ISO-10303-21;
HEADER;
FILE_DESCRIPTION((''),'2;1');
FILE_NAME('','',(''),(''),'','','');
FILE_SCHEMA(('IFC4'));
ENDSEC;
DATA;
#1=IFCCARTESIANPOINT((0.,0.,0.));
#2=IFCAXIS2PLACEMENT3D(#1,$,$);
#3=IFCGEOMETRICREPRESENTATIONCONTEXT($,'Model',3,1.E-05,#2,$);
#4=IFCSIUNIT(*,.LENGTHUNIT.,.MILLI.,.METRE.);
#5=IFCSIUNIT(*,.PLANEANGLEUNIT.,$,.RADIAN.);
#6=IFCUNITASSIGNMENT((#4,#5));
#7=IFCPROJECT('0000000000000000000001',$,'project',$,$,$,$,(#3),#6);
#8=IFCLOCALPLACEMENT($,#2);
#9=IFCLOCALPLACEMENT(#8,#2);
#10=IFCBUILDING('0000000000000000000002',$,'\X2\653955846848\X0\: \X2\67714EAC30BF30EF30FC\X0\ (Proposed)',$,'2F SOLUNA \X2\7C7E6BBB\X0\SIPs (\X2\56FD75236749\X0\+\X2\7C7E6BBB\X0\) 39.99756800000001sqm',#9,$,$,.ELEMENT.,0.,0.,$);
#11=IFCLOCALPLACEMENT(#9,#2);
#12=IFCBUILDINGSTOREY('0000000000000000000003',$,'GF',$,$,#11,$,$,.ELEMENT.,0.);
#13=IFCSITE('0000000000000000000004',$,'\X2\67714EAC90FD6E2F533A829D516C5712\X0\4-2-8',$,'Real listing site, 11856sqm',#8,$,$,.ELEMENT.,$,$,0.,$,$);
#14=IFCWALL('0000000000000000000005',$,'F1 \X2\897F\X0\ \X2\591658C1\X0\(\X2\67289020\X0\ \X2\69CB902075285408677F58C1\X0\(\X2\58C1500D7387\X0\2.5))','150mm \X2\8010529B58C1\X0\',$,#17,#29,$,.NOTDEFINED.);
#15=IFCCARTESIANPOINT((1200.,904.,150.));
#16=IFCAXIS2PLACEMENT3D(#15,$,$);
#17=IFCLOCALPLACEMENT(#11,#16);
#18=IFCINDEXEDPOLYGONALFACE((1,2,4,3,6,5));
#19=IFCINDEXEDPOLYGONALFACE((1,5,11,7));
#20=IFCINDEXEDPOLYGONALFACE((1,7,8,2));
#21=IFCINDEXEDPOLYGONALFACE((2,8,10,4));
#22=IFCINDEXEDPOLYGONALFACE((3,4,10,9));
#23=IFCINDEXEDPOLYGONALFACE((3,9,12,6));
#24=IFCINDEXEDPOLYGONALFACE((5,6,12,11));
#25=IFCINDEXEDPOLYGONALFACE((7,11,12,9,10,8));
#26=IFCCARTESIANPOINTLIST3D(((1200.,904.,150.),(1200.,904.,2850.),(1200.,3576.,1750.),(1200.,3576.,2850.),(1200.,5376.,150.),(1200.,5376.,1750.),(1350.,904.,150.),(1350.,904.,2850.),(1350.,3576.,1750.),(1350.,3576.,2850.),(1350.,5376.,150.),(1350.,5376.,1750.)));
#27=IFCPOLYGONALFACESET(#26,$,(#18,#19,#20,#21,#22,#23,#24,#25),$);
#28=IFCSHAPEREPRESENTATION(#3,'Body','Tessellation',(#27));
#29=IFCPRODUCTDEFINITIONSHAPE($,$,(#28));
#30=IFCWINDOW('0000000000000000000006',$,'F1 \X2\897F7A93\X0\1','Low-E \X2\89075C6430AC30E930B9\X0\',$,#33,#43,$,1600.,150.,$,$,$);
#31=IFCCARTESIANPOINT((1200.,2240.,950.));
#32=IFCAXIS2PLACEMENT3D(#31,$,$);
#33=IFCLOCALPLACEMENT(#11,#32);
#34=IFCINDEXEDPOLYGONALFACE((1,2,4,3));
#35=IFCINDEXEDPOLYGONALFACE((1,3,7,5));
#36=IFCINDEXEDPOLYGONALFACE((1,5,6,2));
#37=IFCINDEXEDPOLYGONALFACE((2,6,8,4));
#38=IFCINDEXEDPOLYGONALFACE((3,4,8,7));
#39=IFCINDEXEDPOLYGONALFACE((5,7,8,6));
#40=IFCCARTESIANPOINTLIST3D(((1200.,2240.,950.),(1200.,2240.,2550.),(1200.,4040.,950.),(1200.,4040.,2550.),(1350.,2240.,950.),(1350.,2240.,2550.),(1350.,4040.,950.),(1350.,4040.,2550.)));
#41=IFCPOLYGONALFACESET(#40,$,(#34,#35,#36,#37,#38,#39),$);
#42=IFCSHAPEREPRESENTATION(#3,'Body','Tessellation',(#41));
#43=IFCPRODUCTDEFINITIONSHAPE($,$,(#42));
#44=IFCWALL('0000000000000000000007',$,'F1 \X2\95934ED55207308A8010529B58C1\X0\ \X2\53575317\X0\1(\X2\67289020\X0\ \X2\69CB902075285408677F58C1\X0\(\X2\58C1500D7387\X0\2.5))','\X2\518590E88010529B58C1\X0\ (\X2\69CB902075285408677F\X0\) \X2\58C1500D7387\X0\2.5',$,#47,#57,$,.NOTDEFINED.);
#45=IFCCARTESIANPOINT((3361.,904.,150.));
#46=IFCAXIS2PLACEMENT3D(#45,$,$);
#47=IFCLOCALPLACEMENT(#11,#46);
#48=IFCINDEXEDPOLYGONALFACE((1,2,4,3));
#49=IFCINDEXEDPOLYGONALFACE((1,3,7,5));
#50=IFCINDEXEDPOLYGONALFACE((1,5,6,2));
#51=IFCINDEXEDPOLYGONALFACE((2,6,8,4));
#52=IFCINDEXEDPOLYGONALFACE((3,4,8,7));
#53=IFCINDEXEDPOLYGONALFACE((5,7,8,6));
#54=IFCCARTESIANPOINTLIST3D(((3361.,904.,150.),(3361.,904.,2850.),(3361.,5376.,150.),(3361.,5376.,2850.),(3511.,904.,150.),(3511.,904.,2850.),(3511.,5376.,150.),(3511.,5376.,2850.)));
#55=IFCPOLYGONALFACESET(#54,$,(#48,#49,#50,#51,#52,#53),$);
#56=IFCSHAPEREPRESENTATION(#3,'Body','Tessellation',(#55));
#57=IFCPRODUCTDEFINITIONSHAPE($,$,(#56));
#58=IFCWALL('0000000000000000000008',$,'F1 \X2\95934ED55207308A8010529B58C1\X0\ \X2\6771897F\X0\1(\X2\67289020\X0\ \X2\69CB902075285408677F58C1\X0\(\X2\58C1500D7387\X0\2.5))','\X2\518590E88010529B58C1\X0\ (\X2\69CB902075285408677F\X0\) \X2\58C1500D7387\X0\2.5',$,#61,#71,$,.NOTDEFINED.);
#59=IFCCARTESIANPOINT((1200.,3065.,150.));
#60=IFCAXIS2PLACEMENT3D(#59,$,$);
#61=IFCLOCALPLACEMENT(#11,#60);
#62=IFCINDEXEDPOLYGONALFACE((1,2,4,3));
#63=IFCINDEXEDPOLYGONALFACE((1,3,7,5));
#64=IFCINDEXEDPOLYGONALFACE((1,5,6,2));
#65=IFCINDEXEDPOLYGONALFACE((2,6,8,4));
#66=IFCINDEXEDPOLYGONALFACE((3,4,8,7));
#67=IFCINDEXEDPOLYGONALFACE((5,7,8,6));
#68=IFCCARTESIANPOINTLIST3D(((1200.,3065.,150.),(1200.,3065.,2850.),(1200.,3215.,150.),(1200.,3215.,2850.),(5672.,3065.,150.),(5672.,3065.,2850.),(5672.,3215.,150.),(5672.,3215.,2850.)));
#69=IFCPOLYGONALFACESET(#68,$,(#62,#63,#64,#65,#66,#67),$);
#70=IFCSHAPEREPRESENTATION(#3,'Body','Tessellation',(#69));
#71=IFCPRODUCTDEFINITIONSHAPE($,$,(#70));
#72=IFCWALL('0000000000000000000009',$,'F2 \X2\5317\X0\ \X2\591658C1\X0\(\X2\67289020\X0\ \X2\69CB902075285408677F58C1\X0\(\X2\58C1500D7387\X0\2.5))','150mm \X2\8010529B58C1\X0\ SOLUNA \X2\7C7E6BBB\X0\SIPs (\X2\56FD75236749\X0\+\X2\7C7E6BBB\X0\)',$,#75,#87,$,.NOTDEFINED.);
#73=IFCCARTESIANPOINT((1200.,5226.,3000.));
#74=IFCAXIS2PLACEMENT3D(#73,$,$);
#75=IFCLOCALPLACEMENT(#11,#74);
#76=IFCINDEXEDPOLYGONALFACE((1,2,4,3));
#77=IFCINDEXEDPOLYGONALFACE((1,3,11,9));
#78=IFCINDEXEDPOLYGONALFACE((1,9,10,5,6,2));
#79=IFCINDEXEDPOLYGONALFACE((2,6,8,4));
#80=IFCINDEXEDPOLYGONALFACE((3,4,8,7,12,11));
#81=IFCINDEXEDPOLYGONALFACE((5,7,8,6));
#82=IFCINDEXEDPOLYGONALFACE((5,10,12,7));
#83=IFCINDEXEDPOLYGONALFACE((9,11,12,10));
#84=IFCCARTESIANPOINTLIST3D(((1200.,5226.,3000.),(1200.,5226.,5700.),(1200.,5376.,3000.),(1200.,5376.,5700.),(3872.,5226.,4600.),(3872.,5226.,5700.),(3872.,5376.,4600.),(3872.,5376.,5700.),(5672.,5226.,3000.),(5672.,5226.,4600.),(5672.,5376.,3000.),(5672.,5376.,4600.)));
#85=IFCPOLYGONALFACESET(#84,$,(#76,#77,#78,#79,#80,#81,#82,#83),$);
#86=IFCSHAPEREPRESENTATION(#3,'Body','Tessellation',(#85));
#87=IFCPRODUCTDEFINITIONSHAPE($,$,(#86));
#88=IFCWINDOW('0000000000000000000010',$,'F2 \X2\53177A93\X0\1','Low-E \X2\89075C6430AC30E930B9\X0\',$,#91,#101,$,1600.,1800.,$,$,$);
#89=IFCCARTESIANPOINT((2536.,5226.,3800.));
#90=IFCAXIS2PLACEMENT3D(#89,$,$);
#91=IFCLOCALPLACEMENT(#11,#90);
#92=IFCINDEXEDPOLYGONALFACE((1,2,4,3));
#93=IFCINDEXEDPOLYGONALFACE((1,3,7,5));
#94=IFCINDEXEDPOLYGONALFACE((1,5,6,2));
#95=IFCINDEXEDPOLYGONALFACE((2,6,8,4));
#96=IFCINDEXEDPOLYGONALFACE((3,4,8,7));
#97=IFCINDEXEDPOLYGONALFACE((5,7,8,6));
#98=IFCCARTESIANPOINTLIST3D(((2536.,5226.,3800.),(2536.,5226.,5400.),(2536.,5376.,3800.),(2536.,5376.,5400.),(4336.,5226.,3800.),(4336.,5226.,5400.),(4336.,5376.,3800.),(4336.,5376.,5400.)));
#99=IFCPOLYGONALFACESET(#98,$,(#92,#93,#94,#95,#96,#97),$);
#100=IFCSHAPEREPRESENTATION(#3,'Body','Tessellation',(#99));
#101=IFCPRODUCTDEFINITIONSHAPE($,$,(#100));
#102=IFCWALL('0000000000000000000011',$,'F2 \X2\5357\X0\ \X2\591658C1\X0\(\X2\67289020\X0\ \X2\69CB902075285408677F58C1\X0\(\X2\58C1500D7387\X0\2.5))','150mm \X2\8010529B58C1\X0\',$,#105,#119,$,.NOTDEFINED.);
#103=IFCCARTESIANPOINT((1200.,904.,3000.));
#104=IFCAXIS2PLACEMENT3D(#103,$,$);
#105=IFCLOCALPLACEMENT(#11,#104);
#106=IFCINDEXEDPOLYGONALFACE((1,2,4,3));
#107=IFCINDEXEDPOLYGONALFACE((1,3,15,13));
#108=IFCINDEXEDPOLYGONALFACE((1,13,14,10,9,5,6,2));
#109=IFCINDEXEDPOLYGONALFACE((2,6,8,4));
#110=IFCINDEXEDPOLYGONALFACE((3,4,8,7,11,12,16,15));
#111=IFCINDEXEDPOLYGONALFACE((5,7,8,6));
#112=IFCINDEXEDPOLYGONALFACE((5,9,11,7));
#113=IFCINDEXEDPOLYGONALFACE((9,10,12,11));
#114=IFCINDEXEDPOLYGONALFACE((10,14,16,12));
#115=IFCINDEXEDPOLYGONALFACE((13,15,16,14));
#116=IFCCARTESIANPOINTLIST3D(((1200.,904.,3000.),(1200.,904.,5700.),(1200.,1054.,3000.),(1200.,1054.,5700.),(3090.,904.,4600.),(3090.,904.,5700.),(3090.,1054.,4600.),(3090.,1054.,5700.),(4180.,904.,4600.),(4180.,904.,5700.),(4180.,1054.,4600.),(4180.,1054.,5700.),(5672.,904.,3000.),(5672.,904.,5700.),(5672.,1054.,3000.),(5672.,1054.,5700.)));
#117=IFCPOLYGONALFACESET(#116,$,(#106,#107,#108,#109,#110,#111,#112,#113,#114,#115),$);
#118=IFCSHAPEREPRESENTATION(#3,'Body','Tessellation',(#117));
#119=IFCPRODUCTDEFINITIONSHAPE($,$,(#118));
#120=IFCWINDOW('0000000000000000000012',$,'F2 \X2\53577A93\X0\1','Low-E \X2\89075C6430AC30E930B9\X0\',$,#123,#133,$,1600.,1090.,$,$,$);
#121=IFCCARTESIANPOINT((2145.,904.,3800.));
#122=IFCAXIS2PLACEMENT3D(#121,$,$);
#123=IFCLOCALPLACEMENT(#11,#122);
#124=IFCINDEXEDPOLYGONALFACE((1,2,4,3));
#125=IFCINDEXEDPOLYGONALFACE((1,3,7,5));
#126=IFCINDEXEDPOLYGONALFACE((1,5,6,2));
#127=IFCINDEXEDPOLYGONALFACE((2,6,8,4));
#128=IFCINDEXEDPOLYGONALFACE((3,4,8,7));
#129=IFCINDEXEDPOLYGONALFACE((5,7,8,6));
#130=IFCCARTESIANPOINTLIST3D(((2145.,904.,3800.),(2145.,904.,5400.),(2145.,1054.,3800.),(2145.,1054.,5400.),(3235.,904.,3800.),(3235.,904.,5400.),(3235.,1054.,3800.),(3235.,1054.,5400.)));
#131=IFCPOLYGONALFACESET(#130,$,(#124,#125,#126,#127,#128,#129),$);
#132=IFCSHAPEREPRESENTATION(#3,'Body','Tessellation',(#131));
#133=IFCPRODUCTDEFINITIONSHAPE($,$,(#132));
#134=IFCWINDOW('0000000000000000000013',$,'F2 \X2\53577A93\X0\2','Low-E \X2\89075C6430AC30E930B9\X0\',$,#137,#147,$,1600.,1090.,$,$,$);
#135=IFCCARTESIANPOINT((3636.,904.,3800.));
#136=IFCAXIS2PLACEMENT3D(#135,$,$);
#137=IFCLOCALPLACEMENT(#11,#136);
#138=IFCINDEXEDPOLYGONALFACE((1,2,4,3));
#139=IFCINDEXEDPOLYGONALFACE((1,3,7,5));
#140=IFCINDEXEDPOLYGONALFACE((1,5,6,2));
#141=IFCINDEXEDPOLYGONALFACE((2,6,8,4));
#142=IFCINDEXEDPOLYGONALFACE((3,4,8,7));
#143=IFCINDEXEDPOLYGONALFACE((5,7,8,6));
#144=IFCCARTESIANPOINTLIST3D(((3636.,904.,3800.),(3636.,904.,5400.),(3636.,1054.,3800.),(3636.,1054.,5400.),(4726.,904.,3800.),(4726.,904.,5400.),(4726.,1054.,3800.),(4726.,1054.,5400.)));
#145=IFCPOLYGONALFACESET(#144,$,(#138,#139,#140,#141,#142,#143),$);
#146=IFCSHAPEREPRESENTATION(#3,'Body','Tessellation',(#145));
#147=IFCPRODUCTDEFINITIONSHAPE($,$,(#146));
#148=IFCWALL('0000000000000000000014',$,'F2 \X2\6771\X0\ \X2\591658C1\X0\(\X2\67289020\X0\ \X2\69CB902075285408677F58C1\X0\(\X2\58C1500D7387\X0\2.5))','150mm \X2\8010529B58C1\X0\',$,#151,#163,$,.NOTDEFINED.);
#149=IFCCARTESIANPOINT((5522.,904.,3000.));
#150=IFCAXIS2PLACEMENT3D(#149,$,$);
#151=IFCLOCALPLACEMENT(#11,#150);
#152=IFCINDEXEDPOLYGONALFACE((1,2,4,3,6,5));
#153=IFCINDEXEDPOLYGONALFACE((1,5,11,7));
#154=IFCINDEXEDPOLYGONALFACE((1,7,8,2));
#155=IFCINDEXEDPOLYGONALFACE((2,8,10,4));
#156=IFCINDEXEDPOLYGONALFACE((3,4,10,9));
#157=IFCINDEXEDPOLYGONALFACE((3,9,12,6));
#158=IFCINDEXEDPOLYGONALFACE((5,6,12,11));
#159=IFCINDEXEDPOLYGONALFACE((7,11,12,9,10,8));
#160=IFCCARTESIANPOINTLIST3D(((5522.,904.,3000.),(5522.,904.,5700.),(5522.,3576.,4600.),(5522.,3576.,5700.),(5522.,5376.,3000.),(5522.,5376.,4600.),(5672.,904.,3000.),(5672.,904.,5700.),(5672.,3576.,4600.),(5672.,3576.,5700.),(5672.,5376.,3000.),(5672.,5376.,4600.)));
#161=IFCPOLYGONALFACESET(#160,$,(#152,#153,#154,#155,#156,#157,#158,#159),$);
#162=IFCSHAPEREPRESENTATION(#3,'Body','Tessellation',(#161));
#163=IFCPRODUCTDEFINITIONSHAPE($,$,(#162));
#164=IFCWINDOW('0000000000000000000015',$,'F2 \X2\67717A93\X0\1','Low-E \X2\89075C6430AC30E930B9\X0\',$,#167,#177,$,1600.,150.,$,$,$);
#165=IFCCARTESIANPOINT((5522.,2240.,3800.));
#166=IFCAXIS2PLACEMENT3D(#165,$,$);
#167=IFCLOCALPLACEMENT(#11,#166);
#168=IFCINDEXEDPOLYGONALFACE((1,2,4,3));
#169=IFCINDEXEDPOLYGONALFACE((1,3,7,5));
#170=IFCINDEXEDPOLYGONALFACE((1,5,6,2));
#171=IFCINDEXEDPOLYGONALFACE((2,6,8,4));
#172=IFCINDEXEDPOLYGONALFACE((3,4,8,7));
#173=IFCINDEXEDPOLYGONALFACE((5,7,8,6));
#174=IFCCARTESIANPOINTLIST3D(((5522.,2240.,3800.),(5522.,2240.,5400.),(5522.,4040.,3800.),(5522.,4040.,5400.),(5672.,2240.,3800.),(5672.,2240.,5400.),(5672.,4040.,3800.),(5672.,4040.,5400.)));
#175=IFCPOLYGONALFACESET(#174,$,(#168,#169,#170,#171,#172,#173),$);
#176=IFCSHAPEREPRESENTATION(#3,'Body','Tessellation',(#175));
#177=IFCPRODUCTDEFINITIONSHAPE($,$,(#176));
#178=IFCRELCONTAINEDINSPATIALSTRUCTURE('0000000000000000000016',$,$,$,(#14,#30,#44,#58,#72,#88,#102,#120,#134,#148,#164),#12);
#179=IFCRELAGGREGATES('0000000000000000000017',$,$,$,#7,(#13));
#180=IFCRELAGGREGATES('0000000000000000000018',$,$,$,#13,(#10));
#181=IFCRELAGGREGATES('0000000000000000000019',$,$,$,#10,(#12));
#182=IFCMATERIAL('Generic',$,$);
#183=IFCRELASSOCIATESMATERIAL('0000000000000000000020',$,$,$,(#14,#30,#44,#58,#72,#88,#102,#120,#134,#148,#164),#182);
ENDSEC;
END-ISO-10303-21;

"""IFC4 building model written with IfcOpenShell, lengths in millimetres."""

from ifc_helpers import new_model, si_unit, frame, frame_2d, origin, place, context, project, spatial, rectangle, extrude, material, element, fill, save


model = new_model("IFC4")

# Units and contexts
model_context = context("Model", 3, precision=1e-05, world=origin())
ifc_project = project(units=[si_unit("LENGTHUNIT", "METRE", prefix="MILLI"), si_unit("PLANEANGLEUNIT", "RADIAN")], contexts=[model_context])

# Site, building, storey
site_placement = place(None, origin())
site = spatial("IfcSite", under=ifc_project, at=site_placement, Name="東京都港区芝公園4-2-8", ObjectType="Real listing site, 11856sqm", CompositionType="ELEMENT", RefElevation=0.0)
building_placement = place(site_placement, origin())
building = spatial("IfcBuilding", under=site, at=building_placement, Name="改善案: 東京タワー (Proposed)", ObjectType="2F SOLUNA 籾殻SIPs (国産杉+籾殻) 39.99756800000001sqm", CompositionType="ELEMENT", ElevationOfRefHeight=0.0, ElevationOfTerrain=0.0)
storey_placement = place(building_placement, origin())
storey = spatial("IfcBuildingStorey", under=building, at=storey_placement, Name="GF", CompositionType="ELEMENT", Elevation=0.0)

# Shared definitions
ifc_material_1 = material(Name="Generic")

# Wall, opening, window
wall_1_placement = place(storey_placement, frame((1200.0, 904.0, 150.0)))
wall_1 = element("IfcWall", 1, at=wall_1_placement, inside=storey, material=ifc_material_1, Name="F1 西 外壁(木造 構造用合板壁(壁倍率2.5))", Description="150mm 耐力壁", PredefinedType="NOTDEFINED", context=model_context, shape_type="SweptSolid", body=[
    extrude(rectangle(XDim=150.0, YDim=4472.0, at=frame_2d((75.0, 2236.0))), frame((1200.0, 904.0, 150.0)), (0.0, 0.0, 1.0), 2700.0),
])
opening_1_placement = place(storey_placement, frame((1200.0, 2240.0, 950.0)))
opening_1 = element("IfcOpeningElement", 2, at=opening_1_placement, cuts=wall_1, PredefinedType="NOTDEFINED", context=model_context, shape_type="SweptSolid", body=[
    extrude(rectangle(XDim=150.0, YDim=1800.0, at=frame_2d((75.0, 900.0))), frame((1200.0, 2240.0, 950.0)), (0.0, 0.0, 1.0), 1600.0),
])
window_1_placement = place(storey_placement, frame((1200.0, 2240.0, 950.0)))
window_1 = element("IfcWindow", 3, at=window_1_placement, inside=storey, material=ifc_material_1, Name="F1 西窓1", Description="Low-E 複層ガラス", OverallHeight=1600.0, OverallWidth=150.0, context=model_context, shape_type="SweptSolid", body=[
    extrude(rectangle(XDim=150.0, YDim=1800.0, at=frame_2d((75.0, 900.0))), frame((1200.0, 2240.0, 950.0)), (0.0, 0.0, 1.0), 1600.0),
])
fill(opening_1, window_1)

# Walls
wall_2_placement = place(storey_placement, frame((3361.0, 904.0, 150.0)))
element("IfcWall", 4, at=wall_2_placement, inside=storey, material=ifc_material_1, Name="F1 間仕切り耐力壁 南北1(木造 構造用合板壁(壁倍率2.5))", Description="内部耐力壁 (構造用合板) 壁倍率2.5", PredefinedType="NOTDEFINED", context=model_context, shape_type="SweptSolid", body=[
    extrude(rectangle(XDim=150.0, YDim=4472.0, at=frame_2d((75.0, 2236.0))), frame((3361.0, 904.0, 150.0)), (0.0, 0.0, 1.0), 2700.0),
])
wall_3_placement = place(storey_placement, frame((1200.0, 3065.0, 150.0)))
element("IfcWall", 5, at=wall_3_placement, inside=storey, material=ifc_material_1, Name="F1 間仕切り耐力壁 東西1(木造 構造用合板壁(壁倍率2.5))", Description="内部耐力壁 (構造用合板) 壁倍率2.5", PredefinedType="NOTDEFINED", context=model_context, shape_type="SweptSolid", body=[
    extrude(rectangle(XDim=4472.0, YDim=150.0, at=frame_2d((2236.0, 75.0))), frame((1200.0, 3065.0, 150.0)), (0.0, 0.0, 1.0), 2700.0),
])

# Wall, opening, window
wall_4_placement = place(storey_placement, frame((1200.0, 5226.0, 3000.0)))
wall_4 = element("IfcWall", 6, at=wall_4_placement, inside=storey, material=ifc_material_1, Name="F2 北 外壁(木造 構造用合板壁(壁倍率2.5))", Description="150mm 耐力壁 SOLUNA 籾殻SIPs (国産杉+籾殻)", PredefinedType="NOTDEFINED", context=model_context, shape_type="SweptSolid", body=[
    extrude(rectangle(XDim=4472.0, YDim=150.0, at=frame_2d((2236.0, 75.0))), frame((1200.0, 5226.0, 3000.0)), (0.0, 0.0, 1.0), 2700.0),
])
opening_2_placement = place(storey_placement, frame((2536.0, 5226.0, 3800.0)))
opening_2 = element("IfcOpeningElement", 7, at=opening_2_placement, cuts=wall_4, PredefinedType="NOTDEFINED", context=model_context, shape_type="SweptSolid", body=[
    extrude(rectangle(XDim=1800.0, YDim=150.0, at=frame_2d((900.0, 75.0))), frame((2536.0, 5226.0, 3800.0)), (0.0, 0.0, 1.0), 1600.0),
])
window_2_placement = place(storey_placement, frame((2536.0, 5226.0, 3800.0)))
window_2 = element("IfcWindow", 8, at=window_2_placement, inside=storey, material=ifc_material_1, Name="F2 北窓1", Description="Low-E 複層ガラス", OverallHeight=1600.0, OverallWidth=1800.0, context=model_context, shape_type="SweptSolid", body=[
    extrude(rectangle(XDim=1800.0, YDim=150.0, at=frame_2d((900.0, 75.0))), frame((2536.0, 5226.0, 3800.0)), (0.0, 0.0, 1.0), 1600.0),
])
fill(opening_2, window_2)

# Wall, openings, windows
wall_5_placement = place(storey_placement, frame((1200.0, 904.0, 3000.0)))
wall_5 = element("IfcWall", 9, at=wall_5_placement, inside=storey, material=ifc_material_1, Name="F2 南 外壁(木造 構造用合板壁(壁倍率2.5))", Description="150mm 耐力壁", PredefinedType="NOTDEFINED", context=model_context, shape_type="SweptSolid", body=[
    extrude(rectangle(XDim=4472.0, YDim=150.0, at=frame_2d((2236.0, 75.0))), frame((1200.0, 904.0, 3000.0)), (0.0, 0.0, 1.0), 2700.0),
])
opening_3_placement = place(storey_placement, frame((2145.0, 904.0, 3800.0)))
opening_3 = element("IfcOpeningElement", 10, at=opening_3_placement, cuts=wall_5, PredefinedType="NOTDEFINED", context=model_context, shape_type="SweptSolid", body=[
    extrude(rectangle(XDim=1090.0, YDim=150.0, at=frame_2d((545.0, 75.0))), frame((2145.0, 904.0, 3800.0)), (0.0, 0.0, 1.0), 1600.0),
])
opening_4_placement = place(storey_placement, frame((3636.0, 904.0, 3800.0)))
opening_4 = element("IfcOpeningElement", 11, at=opening_4_placement, cuts=wall_5, PredefinedType="NOTDEFINED", context=model_context, shape_type="SweptSolid", body=[
    extrude(rectangle(XDim=1090.0, YDim=150.0, at=frame_2d((545.0, 75.0))), frame((3636.0, 904.0, 3800.0)), (0.0, 0.0, 1.0), 1600.0),
])
window_3_placement = place(storey_placement, frame((2145.0, 904.0, 3800.0)))
window_3 = element("IfcWindow", 12, at=window_3_placement, inside=storey, material=ifc_material_1, Name="F2 南窓1", Description="Low-E 複層ガラス", OverallHeight=1600.0, OverallWidth=1090.0, context=model_context, shape_type="SweptSolid", body=[
    extrude(rectangle(XDim=1090.0, YDim=150.0, at=frame_2d((545.0, 75.0))), frame((2145.0, 904.0, 3800.0)), (0.0, 0.0, 1.0), 1600.0),
])
fill(opening_3, window_3)
window_4_placement = place(storey_placement, frame((3636.0, 904.0, 3800.0)))
window_4 = element("IfcWindow", 13, at=window_4_placement, inside=storey, material=ifc_material_1, Name="F2 南窓2", Description="Low-E 複層ガラス", OverallHeight=1600.0, OverallWidth=1090.0, context=model_context, shape_type="SweptSolid", body=[
    extrude(rectangle(XDim=1090.0, YDim=150.0, at=frame_2d((545.0, 75.0))), frame((3636.0, 904.0, 3800.0)), (0.0, 0.0, 1.0), 1600.0),
])
fill(opening_4, window_4)

# Wall, opening, window
wall_6_placement = place(storey_placement, frame((5522.0, 904.0, 3000.0)))
wall_6 = element("IfcWall", 14, at=wall_6_placement, inside=storey, material=ifc_material_1, Name="F2 東 外壁(木造 構造用合板壁(壁倍率2.5))", Description="150mm 耐力壁", PredefinedType="NOTDEFINED", context=model_context, shape_type="SweptSolid", body=[
    extrude(rectangle(XDim=150.0, YDim=4472.0, at=frame_2d((75.0, 2236.0))), frame((5522.0, 904.0, 3000.0)), (0.0, 0.0, 1.0), 2700.0),
])
opening_5_placement = place(storey_placement, frame((5522.0, 2240.0, 3800.0)))
opening_5 = element("IfcOpeningElement", 15, at=opening_5_placement, cuts=wall_6, PredefinedType="NOTDEFINED", context=model_context, shape_type="SweptSolid", body=[
    extrude(rectangle(XDim=150.0, YDim=1800.0, at=frame_2d((75.0, 900.0))), frame((5522.0, 2240.0, 3800.0)), (0.0, 0.0, 1.0), 1600.0),
])
window_5_placement = place(storey_placement, frame((5522.0, 2240.0, 3800.0)))
window_5 = element("IfcWindow", 16, at=window_5_placement, inside=storey, material=ifc_material_1, Name="F2 東窓1", Description="Low-E 複層ガラス", OverallHeight=1600.0, OverallWidth=150.0, context=model_context, shape_type="SweptSolid", body=[
    extrude(rectangle(XDim=150.0, YDim=1800.0, at=frame_2d((75.0, 900.0))), frame((5522.0, 2240.0, 3800.0)), (0.0, 0.0, 1.0), 1600.0),
])
fill(opening_5, window_5)

save(model, "model.ifc")
